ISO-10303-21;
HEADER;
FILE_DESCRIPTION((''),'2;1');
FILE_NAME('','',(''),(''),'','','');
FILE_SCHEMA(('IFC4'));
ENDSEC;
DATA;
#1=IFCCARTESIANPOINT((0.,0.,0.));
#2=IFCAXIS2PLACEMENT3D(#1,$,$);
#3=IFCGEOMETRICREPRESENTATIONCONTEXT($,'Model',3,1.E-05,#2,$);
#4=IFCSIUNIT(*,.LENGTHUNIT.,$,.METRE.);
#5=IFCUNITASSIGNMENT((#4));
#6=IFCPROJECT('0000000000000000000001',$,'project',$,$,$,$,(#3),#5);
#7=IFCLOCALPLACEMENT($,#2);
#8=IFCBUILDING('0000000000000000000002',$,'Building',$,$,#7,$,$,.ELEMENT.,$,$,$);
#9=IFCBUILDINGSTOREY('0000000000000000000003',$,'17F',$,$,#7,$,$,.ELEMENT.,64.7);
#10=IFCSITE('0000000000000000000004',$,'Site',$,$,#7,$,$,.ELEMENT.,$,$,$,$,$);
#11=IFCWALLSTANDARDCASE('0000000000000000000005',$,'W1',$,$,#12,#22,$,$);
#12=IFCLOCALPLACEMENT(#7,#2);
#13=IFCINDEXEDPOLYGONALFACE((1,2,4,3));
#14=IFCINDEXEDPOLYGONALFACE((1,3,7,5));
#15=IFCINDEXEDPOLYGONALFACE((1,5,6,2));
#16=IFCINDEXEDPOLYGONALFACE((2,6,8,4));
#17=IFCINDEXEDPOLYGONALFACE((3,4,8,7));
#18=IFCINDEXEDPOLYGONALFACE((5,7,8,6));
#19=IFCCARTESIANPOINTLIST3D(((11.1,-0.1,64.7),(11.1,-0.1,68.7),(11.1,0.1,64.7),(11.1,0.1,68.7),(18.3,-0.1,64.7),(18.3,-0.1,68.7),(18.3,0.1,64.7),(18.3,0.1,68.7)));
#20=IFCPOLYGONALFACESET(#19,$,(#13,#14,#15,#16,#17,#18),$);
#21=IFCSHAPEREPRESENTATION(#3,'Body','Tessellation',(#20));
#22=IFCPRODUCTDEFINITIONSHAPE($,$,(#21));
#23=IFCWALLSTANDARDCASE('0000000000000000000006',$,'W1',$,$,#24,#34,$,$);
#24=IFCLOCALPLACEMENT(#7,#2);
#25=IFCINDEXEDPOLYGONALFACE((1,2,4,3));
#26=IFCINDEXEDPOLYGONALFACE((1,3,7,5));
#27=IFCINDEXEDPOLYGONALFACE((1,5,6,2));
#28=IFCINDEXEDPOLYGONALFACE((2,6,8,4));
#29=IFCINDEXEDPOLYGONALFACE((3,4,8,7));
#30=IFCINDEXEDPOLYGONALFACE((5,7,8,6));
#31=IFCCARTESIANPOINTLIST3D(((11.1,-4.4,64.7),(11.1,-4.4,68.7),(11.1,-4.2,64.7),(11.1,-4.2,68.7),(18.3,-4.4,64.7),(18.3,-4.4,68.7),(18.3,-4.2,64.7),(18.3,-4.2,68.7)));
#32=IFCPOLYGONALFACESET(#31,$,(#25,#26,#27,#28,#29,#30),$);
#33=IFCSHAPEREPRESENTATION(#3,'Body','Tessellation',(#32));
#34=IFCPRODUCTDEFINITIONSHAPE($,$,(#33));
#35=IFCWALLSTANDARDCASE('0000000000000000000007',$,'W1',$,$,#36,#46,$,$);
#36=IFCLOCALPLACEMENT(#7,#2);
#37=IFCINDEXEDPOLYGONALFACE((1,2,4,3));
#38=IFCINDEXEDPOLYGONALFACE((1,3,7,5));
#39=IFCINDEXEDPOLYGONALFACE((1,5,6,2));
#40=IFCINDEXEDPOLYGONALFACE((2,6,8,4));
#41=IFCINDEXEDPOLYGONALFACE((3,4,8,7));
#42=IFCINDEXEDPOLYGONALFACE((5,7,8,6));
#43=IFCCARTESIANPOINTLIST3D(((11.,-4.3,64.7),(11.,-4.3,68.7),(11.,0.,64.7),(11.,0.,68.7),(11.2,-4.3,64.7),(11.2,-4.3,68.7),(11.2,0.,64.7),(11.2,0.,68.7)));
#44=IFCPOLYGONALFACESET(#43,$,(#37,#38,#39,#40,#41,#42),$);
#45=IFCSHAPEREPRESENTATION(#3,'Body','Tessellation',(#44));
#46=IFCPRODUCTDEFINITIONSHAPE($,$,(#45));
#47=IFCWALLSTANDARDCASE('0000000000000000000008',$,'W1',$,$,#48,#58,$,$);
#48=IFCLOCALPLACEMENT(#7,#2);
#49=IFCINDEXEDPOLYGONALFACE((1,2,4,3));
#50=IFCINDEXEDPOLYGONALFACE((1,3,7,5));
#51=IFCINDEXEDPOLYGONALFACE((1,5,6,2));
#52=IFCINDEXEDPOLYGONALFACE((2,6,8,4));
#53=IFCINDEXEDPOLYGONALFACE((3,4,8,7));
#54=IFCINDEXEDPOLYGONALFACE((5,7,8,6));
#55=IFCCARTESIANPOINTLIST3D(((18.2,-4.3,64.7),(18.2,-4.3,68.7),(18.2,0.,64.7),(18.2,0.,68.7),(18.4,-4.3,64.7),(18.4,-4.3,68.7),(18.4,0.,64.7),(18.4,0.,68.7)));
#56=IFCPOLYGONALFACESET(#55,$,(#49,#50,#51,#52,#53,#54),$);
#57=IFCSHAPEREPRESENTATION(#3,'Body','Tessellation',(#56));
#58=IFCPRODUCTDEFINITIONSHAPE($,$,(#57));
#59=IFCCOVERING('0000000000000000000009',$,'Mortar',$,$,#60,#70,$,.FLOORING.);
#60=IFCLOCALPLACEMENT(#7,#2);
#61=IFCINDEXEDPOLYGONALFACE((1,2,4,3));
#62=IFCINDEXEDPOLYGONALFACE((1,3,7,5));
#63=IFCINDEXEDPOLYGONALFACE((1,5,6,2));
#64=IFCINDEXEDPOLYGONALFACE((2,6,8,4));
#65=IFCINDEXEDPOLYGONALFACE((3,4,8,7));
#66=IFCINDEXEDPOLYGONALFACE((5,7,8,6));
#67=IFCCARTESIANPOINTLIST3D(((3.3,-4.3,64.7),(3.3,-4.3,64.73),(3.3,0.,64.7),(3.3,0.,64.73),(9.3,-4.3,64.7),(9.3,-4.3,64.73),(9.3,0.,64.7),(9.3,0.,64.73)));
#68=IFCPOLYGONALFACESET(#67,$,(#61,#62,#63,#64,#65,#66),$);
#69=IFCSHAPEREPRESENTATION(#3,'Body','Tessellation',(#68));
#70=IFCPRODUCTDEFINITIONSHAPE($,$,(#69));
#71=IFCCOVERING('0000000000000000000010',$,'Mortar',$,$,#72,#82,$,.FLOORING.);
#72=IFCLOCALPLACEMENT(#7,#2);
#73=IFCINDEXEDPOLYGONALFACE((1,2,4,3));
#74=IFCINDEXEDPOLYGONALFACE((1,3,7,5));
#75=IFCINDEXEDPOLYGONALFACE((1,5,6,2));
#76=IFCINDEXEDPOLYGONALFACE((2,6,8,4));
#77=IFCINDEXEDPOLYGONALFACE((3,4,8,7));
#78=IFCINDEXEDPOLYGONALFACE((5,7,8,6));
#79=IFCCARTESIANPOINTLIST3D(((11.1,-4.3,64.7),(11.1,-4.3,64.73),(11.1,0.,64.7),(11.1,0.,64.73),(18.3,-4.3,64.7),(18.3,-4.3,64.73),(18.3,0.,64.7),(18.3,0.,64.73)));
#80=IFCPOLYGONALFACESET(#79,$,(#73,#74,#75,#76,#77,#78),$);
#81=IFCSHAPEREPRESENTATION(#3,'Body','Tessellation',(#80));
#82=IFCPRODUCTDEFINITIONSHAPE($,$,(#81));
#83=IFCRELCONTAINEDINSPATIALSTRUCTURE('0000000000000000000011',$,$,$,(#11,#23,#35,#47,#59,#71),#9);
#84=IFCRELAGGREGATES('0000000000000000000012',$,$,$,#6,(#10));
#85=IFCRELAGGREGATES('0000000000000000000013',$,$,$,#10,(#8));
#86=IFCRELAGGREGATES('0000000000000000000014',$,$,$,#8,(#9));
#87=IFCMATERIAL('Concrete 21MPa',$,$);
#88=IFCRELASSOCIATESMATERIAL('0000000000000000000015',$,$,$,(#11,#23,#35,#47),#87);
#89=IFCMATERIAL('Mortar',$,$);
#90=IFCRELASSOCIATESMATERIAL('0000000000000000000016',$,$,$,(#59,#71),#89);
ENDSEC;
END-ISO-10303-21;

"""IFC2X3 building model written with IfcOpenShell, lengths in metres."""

from ifc_helpers import new_model, si_unit, frame, origin, origin_2d, place, context, project, spatial, rectangle, extrude, material, element, save


model = new_model("IFC2X3")

# Units and contexts
model_context = context("Model", 3, precision=1e-05, world=origin())
ifc_project = project(units=[si_unit("LENGTHUNIT", "METRE")], contexts=[model_context])

# Site, building, storey
placement = place(None, origin())
site = spatial("IfcSite", under=ifc_project, at=placement, Name="Site", CompositionType="ELEMENT")
building = spatial("IfcBuilding", under=site, at=placement, Name="Building", CompositionType="ELEMENT")
storey = spatial("IfcBuildingStorey", under=building, at=placement, Name="17F", CompositionType="ELEMENT", Elevation=64.7)

# Shared definitions
ifc_material_1 = material(Name="Concrete 21MPa")

# Walls
for number, where, name in (
    (1, (14.7, 0.0, 64.7), "W1"),
    (2, (14.7, -4.3, 64.7), "W1"),
):
    element("IfcWallStandardCase", number, at=place(None, frame(where)), inside=storey, material=ifc_material_1, Name=name, context=model_context, shape_type="SweptSolid", body=[
        extrude(rectangle(XDim=7.2, YDim=0.2, at=origin_2d()), origin(), (0.0, 0.0, 1.0), 4.0),
    ])
for number, where, name in (
    (3, (11.1, -2.15, 64.7), "W1"),
    (4, (18.3, -2.15, 64.7), "W1"),
):
    element("IfcWallStandardCase", number, at=place(None, frame(where)), inside=storey, material=ifc_material_1, Name=name, context=model_context, shape_type="SweptSolid", body=[
        extrude(rectangle(XDim=0.2, YDim=4.3, at=origin_2d()), origin(), (0.0, 0.0, 1.0), 4.0),
    ])

# Coverings
ifc_material_2 = material(Name="Mortar")
covering_1_placement = place(None, frame((6.3, -2.15, 64.7)))
element("IfcCovering", 5, at=covering_1_placement, inside=storey, material=ifc_material_2, Name="Mortar", PredefinedType="FLOORING", context=model_context, shape_type="SweptSolid", body=[
    extrude(rectangle(XDim=6.0, YDim=4.3, at=origin_2d()), origin(), (0.0, 0.0, 1.0), 0.03),
])
covering_2_placement = place(None, frame((14.7, -2.15, 64.7)))
element("IfcCovering", 6, at=covering_2_placement, inside=storey, material=ifc_material_2, Name="Mortar", PredefinedType="FLOORING", context=model_context, shape_type="SweptSolid", body=[
    extrude(rectangle(XDim=7.2, YDim=4.3, at=origin_2d()), origin(), (0.0, 0.0, 1.0), 0.03),
])

save(model, "model.ifc")
